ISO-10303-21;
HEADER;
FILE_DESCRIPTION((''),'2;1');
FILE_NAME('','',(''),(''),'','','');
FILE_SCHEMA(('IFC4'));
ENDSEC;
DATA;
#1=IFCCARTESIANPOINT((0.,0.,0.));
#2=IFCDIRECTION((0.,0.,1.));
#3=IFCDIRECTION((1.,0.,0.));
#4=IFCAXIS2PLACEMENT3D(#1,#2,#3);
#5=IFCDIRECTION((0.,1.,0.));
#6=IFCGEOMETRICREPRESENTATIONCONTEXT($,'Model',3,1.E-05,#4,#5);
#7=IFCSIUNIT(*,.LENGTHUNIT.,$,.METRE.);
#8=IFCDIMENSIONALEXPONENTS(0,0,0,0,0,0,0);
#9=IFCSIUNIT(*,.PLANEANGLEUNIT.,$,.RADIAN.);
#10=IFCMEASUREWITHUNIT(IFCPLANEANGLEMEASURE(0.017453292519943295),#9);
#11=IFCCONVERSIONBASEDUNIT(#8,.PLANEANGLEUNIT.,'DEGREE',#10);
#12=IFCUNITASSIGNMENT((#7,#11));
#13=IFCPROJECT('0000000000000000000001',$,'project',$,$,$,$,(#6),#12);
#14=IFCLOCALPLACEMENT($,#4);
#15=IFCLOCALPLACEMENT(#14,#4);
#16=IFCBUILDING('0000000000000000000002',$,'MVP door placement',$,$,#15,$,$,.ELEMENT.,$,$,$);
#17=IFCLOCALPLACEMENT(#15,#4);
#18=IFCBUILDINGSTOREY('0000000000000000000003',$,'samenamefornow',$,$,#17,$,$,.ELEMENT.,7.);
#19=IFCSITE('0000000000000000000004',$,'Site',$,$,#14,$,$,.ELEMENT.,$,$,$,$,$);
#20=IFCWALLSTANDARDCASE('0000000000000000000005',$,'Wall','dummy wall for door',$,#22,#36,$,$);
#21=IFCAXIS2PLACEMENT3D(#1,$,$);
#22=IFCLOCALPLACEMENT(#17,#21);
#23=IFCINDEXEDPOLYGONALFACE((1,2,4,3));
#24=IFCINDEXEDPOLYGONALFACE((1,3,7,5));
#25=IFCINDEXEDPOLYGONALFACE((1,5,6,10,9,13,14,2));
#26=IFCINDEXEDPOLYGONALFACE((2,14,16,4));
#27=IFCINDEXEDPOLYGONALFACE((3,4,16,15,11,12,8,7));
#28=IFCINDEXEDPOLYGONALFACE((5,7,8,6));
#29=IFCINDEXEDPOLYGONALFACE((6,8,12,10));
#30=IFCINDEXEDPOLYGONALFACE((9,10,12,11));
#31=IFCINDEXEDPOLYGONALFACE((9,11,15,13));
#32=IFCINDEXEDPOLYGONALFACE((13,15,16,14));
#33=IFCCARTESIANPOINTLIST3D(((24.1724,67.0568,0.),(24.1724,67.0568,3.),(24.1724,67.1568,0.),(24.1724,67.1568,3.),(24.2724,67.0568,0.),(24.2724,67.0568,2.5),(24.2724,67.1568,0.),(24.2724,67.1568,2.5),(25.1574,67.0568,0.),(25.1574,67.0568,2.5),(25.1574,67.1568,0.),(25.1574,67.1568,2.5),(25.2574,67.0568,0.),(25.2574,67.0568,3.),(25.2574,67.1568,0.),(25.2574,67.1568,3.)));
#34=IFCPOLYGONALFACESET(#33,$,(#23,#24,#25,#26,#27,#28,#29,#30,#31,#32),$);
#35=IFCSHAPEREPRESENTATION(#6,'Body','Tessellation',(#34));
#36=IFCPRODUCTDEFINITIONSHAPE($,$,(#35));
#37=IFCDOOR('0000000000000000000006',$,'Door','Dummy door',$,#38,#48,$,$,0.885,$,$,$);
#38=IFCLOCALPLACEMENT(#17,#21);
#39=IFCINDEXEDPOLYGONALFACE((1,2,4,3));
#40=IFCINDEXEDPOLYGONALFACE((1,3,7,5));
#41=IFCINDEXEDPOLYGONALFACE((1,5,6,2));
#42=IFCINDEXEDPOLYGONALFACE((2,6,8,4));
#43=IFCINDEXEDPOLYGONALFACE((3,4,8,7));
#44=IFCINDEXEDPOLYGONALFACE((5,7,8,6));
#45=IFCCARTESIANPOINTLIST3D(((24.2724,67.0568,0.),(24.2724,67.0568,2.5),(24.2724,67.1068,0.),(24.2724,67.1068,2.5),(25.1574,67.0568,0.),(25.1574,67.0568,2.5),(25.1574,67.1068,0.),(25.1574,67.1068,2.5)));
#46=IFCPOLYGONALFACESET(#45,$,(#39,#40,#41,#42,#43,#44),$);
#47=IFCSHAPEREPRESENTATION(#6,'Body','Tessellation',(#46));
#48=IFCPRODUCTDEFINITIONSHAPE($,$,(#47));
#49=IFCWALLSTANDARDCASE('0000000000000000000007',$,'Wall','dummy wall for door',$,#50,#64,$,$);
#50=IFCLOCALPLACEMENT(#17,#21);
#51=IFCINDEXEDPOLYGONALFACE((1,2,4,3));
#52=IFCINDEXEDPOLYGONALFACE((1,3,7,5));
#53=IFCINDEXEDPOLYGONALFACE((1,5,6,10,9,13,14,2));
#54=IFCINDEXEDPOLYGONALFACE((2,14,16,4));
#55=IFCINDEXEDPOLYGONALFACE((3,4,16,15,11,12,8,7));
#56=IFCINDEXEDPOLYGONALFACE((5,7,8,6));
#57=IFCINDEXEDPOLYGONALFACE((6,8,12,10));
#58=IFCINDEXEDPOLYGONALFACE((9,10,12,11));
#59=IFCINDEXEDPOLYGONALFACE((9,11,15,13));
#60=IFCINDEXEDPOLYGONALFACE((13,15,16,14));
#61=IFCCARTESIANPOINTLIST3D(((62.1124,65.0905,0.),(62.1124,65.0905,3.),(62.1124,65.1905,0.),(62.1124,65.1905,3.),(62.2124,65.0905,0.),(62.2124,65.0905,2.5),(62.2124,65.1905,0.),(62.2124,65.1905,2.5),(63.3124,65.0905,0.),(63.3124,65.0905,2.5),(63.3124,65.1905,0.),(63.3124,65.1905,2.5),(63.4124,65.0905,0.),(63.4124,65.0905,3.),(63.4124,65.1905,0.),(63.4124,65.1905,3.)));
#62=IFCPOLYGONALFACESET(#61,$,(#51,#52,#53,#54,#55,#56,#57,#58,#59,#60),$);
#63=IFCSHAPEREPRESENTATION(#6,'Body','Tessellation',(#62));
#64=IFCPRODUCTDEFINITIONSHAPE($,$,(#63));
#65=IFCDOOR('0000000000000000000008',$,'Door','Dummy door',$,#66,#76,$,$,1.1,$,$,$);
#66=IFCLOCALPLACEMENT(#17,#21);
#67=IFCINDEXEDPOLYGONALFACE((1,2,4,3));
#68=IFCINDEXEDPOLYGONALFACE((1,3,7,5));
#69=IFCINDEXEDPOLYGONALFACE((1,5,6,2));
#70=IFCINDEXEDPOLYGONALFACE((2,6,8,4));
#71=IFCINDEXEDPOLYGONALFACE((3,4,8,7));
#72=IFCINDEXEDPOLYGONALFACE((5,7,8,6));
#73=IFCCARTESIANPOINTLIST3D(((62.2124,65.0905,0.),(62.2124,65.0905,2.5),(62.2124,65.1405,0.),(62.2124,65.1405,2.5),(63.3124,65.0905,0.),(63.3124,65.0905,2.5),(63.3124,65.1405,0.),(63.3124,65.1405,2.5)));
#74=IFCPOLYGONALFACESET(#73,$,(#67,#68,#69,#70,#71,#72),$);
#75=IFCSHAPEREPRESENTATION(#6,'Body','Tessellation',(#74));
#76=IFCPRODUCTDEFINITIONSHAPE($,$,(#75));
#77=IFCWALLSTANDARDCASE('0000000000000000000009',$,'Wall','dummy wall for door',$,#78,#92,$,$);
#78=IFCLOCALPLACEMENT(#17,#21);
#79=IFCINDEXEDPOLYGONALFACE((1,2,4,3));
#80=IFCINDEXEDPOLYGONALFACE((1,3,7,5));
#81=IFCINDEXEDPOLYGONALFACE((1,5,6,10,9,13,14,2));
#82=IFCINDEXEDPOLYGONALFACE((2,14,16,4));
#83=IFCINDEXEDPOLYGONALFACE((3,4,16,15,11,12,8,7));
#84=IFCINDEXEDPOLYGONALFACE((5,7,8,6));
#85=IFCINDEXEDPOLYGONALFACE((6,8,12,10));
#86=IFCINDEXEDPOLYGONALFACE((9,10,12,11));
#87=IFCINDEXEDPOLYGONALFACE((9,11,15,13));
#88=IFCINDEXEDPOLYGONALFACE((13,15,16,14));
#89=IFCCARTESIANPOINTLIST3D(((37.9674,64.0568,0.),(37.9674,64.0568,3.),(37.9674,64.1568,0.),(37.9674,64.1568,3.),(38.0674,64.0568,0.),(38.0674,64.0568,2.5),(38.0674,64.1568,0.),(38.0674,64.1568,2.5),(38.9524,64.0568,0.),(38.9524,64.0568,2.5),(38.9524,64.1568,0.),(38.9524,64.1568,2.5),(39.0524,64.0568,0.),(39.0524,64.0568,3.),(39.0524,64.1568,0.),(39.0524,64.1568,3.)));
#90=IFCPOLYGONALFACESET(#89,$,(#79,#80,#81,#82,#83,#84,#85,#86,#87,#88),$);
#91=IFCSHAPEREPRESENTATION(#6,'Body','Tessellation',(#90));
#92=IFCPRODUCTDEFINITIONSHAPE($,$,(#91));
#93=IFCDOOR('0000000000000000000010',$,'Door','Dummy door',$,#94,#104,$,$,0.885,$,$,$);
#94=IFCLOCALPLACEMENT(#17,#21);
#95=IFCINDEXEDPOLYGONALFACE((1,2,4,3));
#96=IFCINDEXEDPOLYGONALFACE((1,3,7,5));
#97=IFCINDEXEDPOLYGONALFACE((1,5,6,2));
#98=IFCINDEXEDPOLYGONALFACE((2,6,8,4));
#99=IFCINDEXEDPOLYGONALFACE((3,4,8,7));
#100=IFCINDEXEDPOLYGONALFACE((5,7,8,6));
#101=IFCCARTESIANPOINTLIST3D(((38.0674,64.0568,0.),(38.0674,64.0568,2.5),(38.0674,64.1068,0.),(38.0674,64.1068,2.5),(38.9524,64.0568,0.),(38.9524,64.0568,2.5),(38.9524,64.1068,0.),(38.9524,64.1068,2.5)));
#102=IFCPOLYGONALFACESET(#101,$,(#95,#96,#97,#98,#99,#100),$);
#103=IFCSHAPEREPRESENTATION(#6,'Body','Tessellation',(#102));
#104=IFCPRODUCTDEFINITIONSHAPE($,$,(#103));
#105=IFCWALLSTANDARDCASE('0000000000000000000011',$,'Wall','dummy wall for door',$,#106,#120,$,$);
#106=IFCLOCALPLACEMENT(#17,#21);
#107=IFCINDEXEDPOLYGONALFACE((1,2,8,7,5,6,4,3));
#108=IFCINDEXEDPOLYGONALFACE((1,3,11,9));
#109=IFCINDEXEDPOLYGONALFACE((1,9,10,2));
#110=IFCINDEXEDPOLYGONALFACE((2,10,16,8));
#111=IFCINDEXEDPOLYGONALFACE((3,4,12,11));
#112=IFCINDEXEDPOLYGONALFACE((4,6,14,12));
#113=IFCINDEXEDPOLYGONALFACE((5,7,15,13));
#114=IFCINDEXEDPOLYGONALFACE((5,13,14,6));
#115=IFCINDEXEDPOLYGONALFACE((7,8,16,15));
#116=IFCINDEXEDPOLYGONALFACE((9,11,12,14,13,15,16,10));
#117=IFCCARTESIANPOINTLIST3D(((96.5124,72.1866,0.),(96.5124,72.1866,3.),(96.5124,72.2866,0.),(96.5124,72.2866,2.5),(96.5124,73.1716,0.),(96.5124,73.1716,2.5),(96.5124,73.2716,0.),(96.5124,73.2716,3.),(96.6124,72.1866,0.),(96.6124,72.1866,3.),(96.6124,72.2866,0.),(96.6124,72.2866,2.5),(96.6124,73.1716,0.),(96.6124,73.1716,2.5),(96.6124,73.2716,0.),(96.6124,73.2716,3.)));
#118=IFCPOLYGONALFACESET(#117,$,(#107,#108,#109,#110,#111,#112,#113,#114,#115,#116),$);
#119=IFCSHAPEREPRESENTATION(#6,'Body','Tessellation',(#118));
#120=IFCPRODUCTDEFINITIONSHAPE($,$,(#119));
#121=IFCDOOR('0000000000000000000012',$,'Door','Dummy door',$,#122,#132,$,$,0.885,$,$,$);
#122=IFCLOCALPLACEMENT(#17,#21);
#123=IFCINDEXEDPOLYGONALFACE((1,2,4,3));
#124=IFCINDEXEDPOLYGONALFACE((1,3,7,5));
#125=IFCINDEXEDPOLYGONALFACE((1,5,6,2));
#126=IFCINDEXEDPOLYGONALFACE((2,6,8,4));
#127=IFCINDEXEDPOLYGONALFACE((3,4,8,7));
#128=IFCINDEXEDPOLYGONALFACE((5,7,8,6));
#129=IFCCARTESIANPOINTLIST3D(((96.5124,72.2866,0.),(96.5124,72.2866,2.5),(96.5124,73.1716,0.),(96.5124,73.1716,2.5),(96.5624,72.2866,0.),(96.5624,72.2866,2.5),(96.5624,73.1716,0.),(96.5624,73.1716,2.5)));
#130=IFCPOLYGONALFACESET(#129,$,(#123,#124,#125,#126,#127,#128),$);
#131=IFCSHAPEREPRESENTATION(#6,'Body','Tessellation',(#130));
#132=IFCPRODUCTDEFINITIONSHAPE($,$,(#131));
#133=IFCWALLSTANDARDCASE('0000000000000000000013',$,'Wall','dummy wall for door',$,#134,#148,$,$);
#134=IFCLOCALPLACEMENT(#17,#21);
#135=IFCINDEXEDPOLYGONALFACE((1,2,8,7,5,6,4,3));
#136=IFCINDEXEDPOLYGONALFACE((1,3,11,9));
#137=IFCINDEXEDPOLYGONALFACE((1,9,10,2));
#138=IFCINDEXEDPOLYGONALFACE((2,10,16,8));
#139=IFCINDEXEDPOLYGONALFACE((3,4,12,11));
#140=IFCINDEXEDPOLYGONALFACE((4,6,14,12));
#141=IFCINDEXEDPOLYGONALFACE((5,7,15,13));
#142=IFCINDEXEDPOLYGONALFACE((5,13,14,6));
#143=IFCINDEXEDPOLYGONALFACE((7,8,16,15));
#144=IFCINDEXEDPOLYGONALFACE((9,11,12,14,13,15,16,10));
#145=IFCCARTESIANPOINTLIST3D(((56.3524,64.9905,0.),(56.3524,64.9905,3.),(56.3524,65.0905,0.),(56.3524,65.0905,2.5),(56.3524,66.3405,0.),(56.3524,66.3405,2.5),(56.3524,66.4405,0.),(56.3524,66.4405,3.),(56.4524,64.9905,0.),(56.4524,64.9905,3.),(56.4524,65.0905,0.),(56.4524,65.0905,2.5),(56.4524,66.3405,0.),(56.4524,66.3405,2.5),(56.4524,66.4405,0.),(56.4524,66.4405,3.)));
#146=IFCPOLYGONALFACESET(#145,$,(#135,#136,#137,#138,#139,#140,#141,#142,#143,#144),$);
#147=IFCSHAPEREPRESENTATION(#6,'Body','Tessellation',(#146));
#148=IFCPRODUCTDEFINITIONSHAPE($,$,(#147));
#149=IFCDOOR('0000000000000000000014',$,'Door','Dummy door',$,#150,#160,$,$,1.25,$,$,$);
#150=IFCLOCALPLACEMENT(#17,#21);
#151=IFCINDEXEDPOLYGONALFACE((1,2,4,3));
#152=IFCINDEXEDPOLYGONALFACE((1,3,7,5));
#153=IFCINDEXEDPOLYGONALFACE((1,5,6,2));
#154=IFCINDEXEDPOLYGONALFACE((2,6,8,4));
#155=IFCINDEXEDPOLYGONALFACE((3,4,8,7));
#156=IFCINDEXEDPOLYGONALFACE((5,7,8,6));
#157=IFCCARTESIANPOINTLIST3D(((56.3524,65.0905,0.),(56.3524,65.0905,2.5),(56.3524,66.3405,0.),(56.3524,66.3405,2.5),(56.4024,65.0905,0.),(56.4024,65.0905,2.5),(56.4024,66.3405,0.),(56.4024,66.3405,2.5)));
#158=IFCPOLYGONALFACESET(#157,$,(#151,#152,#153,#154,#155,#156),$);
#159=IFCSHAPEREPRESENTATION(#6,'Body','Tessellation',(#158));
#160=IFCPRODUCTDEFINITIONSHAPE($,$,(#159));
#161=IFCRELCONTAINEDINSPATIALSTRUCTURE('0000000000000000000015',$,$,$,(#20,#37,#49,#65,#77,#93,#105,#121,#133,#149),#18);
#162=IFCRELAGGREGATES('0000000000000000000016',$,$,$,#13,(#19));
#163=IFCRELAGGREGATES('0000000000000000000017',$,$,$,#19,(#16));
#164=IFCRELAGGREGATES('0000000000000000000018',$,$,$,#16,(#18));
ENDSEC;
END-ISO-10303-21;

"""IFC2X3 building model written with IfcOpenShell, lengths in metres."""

from ifc_helpers import new_model, entity, si_unit, converted_unit, direction, origin_with_axes, place, context, project, spatial, polyline, outline, extrude, element, fill, save


model = new_model("IFC2X3")

# Units and contexts
model_context = context("Model", 3, precision=1e-05, world=origin_with_axes(), true_north=direction((0.0, 1.0, 0.0)))
ifc_project = project(units=[si_unit("LENGTHUNIT", "METRE"), converted_unit("PLANEANGLEUNIT", "DEGREE", entity("IfcPlaneAngleMeasure", 0.017453292519943295), si_unit("PLANEANGLEUNIT", "RADIAN"), dimensions=[0, 0, 0, 0, 0, 0, 0])], contexts=[model_context])

# Site, building, storey
site_placement = place(None, origin_with_axes())
site = spatial("IfcSite", under=ifc_project, at=site_placement, Name="Site", CompositionType="ELEMENT")
building_placement = place(site_placement, origin_with_axes())
building = spatial("IfcBuilding", under=site, at=building_placement, Name="MVP door placement", CompositionType="ELEMENT")
storey_placement = place(building_placement, origin_with_axes())
storey = spatial("IfcBuildingStorey", under=building, at=storey_placement, Name="samenamefornow", CompositionType="ELEMENT", Elevation=7.0)

# Walls, openings, doors
wall_1_placement = place(storey_placement, origin_with_axes())
wall_1 = element("IfcWallStandardCase", 1, at=wall_1_placement, inside=storey, Name="Wall", Description="dummy wall for door", context=model_context, shape_type="SweptSolid", body=[
    extrude(outline(polyline([(25.2574, 67.0568, 0.0), (24.1724, 67.0568, 0.0), (24.1724, 67.1568, 0.0), (25.2574, 67.1568, 0.0), (25.2574, 67.0568, 0.0)])), origin_with_axes(), (0.0, 0.0, 1.0), 3.0),
])
opening_1_placement = place(wall_1_placement, origin_with_axes())
opening_1 = element("IfcOpeningElement", 2, at=opening_1_placement, cuts=wall_1, context=model_context, shape_type="SweptSolid", body=[
    extrude(outline(polyline([(25.1574, 67.0568, 0.0), (24.2724, 67.0568, 0.0), (24.2724, 67.1568, 0.0), (25.1574, 67.1568, 0.0), (25.1574, 67.0568, 0.0)])), origin_with_axes(), (0.0, 0.0, 1.0), 2.5),
])
door_1_placement = place(opening_1_placement, origin_with_axes())
door_1 = element("IfcDoor", 3, at=door_1_placement, inside=storey, Name="Door", Description="Dummy door", OverallWidth=0.885, context=model_context, shape_type="SweptSolid", body=[
    extrude(outline(polyline([(25.1574, 67.0568, 0.0), (24.2724, 67.0568, 0.0), (24.2724, 67.1068, 0.0), (25.1574, 67.1068, 0.0), (25.1574, 67.0568, 0.0)])), origin_with_axes(), (0.0, 0.0, 1.0), 2.5),
])
fill(opening_1, door_1)
wall_2_placement = place(storey_placement, origin_with_axes())
wall_2 = element("IfcWallStandardCase", 4, at=wall_2_placement, inside=storey, Name="Wall", Description="dummy wall for door", context=model_context, shape_type="SweptSolid", body=[
    extrude(outline(polyline([(63.4124, 65.0905, 0.0), (62.1124, 65.0905, 0.0), (62.1124, 65.1905, 0.0), (63.4124, 65.1905, 0.0), (63.4124, 65.0905, 0.0)])), origin_with_axes(), (0.0, 0.0, 1.0), 3.0),
])
opening_2_placement = place(wall_2_placement, origin_with_axes())
opening_2 = element("IfcOpeningElement", 5, at=opening_2_placement, cuts=wall_2, context=model_context, shape_type="SweptSolid", body=[
    extrude(outline(polyline([(63.3124, 65.0905, 0.0), (62.2124, 65.0905, 0.0), (62.2124, 65.1905, 0.0), (63.3124, 65.1905, 0.0), (63.3124, 65.0905, 0.0)])), origin_with_axes(), (0.0, 0.0, 1.0), 2.5),
])
door_2_placement = place(opening_2_placement, origin_with_axes())
door_2 = element("IfcDoor", 6, at=door_2_placement, inside=storey, Name="Door", Description="Dummy door", OverallWidth=1.1, context=model_context, shape_type="SweptSolid", body=[
    extrude(outline(polyline([(63.3124, 65.0905, 0.0), (62.2124, 65.0905, 0.0), (62.2124, 65.1405, 0.0), (63.3124, 65.1405, 0.0), (63.3124, 65.0905, 0.0)])), origin_with_axes(), (0.0, 0.0, 1.0), 2.5),
])
fill(opening_2, door_2)
wall_3_placement = place(storey_placement, origin_with_axes())
wall_3 = element("IfcWallStandardCase", 7, at=wall_3_placement, inside=storey, Name="Wall", Description="dummy wall for door", context=model_context, shape_type="SweptSolid", body=[
    extrude(outline(polyline([(37.9674, 64.0568, 0.0), (39.0524, 64.0568, 0.0), (39.0524, 64.1568, 0.0), (37.9674, 64.1568, 0.0), (37.9674, 64.0568, 0.0)])), origin_with_axes(), (0.0, 0.0, 1.0), 3.0),
])
opening_3_placement = place(wall_3_placement, origin_with_axes())
opening_3 = element("IfcOpeningElement", 8, at=opening_3_placement, cuts=wall_3, context=model_context, shape_type="SweptSolid", body=[
    extrude(outline(polyline([(38.0674, 64.0568, 0.0), (38.9524, 64.0568, 0.0), (38.9524, 64.1568, 0.0), (38.0674, 64.1568, 0.0), (38.0674, 64.0568, 0.0)])), origin_with_axes(), (0.0, 0.0, 1.0), 2.5),
])
door_3_placement = place(opening_3_placement, origin_with_axes())
door_3 = element("IfcDoor", 9, at=door_3_placement, inside=storey, Name="Door", Description="Dummy door", OverallWidth=0.885, context=model_context, shape_type="SweptSolid", body=[
    extrude(outline(polyline([(38.0674, 64.0568, 0.0), (38.9524, 64.0568, 0.0), (38.9524, 64.1068, 0.0), (38.0674, 64.1068, 0.0), (38.0674, 64.0568, 0.0)])), origin_with_axes(), (0.0, 0.0, 1.0), 2.5),
])
fill(opening_3, door_3)
wall_4_placement = place(storey_placement, origin_with_axes())
wall_4 = element("IfcWallStandardCase", 10, at=wall_4_placement, inside=storey, Name="Wall", Description="dummy wall for door", context=model_context, shape_type="SweptSolid", body=[
    extrude(outline(polyline([(96.5124, 73.2716, 0.0), (96.5124, 72.1866, 0.0), (96.6124, 72.1866, 0.0), (96.6124, 73.2716, 0.0), (96.5124, 73.2716, 0.0)])), origin_with_axes(), (0.0, 0.0, 1.0), 3.0),
])
opening_4_placement = place(wall_4_placement, origin_with_axes())
opening_4 = element("IfcOpeningElement", 11, at=opening_4_placement, cuts=wall_4, context=model_context, shape_type="SweptSolid", body=[
    extrude(outline(polyline([(96.5124, 73.1716, 0.0), (96.5124, 72.2866, 0.0), (96.6124, 72.2866, 0.0), (96.6124, 73.1716, 0.0), (96.5124, 73.1716, 0.0)])), origin_with_axes(), (0.0, 0.0, 1.0), 2.5),
])
door_4_placement = place(opening_4_placement, origin_with_axes())
door_4 = element("IfcDoor", 12, at=door_4_placement, inside=storey, Name="Door", Description="Dummy door", OverallWidth=0.885, context=model_context, shape_type="SweptSolid", body=[
    extrude(outline(polyline([(96.5124, 73.1716, 0.0), (96.5124, 72.2866, 0.0), (96.5624, 72.2866, 0.0), (96.5624, 73.1716, 0.0), (96.5124, 73.1716, 0.0)])), origin_with_axes(), (0.0, 0.0, 1.0), 2.5),
])
fill(opening_4, door_4)
wall_5_placement = place(storey_placement, origin_with_axes())
wall_5 = element("IfcWallStandardCase", 13, at=wall_5_placement, inside=storey, Name="Wall", Description="dummy wall for door", context=model_context, shape_type="SweptSolid", body=[
    extrude(outline(polyline([(56.3524, 64.9905, 0.0), (56.3524, 66.4405, 0.0), (56.4524, 66.4405, 0.0), (56.4524, 64.9905, 0.0), (56.3524, 64.9905, 0.0)])), origin_with_axes(), (0.0, 0.0, 1.0), 3.0),
])
opening_5_placement = place(wall_5_placement, origin_with_axes())
opening_5 = element("IfcOpeningElement", 14, at=opening_5_placement, cuts=wall_5, context=model_context, shape_type="SweptSolid", body=[
    extrude(outline(polyline([(56.3524, 65.0905, 0.0), (56.3524, 66.3405, 0.0), (56.4524, 66.3405, 0.0), (56.4524, 65.0905, 0.0), (56.3524, 65.0905, 0.0)])), origin_with_axes(), (0.0, 0.0, 1.0), 2.5),
])
door_5_placement = place(opening_5_placement, origin_with_axes())
door_5 = element("IfcDoor", 15, at=door_5_placement, inside=storey, Name="Door", Description="Dummy door", OverallWidth=1.25, context=model_context, shape_type="SweptSolid", body=[
    extrude(outline(polyline([(56.3524, 65.0905, 0.0), (56.3524, 66.3405, 0.0), (56.4024, 66.3405, 0.0), (56.4024, 65.0905, 0.0), (56.3524, 65.0905, 0.0)])), origin_with_axes(), (0.0, 0.0, 1.0), 2.5),
])
fill(opening_5, door_5)

save(model, "model.ifc")
